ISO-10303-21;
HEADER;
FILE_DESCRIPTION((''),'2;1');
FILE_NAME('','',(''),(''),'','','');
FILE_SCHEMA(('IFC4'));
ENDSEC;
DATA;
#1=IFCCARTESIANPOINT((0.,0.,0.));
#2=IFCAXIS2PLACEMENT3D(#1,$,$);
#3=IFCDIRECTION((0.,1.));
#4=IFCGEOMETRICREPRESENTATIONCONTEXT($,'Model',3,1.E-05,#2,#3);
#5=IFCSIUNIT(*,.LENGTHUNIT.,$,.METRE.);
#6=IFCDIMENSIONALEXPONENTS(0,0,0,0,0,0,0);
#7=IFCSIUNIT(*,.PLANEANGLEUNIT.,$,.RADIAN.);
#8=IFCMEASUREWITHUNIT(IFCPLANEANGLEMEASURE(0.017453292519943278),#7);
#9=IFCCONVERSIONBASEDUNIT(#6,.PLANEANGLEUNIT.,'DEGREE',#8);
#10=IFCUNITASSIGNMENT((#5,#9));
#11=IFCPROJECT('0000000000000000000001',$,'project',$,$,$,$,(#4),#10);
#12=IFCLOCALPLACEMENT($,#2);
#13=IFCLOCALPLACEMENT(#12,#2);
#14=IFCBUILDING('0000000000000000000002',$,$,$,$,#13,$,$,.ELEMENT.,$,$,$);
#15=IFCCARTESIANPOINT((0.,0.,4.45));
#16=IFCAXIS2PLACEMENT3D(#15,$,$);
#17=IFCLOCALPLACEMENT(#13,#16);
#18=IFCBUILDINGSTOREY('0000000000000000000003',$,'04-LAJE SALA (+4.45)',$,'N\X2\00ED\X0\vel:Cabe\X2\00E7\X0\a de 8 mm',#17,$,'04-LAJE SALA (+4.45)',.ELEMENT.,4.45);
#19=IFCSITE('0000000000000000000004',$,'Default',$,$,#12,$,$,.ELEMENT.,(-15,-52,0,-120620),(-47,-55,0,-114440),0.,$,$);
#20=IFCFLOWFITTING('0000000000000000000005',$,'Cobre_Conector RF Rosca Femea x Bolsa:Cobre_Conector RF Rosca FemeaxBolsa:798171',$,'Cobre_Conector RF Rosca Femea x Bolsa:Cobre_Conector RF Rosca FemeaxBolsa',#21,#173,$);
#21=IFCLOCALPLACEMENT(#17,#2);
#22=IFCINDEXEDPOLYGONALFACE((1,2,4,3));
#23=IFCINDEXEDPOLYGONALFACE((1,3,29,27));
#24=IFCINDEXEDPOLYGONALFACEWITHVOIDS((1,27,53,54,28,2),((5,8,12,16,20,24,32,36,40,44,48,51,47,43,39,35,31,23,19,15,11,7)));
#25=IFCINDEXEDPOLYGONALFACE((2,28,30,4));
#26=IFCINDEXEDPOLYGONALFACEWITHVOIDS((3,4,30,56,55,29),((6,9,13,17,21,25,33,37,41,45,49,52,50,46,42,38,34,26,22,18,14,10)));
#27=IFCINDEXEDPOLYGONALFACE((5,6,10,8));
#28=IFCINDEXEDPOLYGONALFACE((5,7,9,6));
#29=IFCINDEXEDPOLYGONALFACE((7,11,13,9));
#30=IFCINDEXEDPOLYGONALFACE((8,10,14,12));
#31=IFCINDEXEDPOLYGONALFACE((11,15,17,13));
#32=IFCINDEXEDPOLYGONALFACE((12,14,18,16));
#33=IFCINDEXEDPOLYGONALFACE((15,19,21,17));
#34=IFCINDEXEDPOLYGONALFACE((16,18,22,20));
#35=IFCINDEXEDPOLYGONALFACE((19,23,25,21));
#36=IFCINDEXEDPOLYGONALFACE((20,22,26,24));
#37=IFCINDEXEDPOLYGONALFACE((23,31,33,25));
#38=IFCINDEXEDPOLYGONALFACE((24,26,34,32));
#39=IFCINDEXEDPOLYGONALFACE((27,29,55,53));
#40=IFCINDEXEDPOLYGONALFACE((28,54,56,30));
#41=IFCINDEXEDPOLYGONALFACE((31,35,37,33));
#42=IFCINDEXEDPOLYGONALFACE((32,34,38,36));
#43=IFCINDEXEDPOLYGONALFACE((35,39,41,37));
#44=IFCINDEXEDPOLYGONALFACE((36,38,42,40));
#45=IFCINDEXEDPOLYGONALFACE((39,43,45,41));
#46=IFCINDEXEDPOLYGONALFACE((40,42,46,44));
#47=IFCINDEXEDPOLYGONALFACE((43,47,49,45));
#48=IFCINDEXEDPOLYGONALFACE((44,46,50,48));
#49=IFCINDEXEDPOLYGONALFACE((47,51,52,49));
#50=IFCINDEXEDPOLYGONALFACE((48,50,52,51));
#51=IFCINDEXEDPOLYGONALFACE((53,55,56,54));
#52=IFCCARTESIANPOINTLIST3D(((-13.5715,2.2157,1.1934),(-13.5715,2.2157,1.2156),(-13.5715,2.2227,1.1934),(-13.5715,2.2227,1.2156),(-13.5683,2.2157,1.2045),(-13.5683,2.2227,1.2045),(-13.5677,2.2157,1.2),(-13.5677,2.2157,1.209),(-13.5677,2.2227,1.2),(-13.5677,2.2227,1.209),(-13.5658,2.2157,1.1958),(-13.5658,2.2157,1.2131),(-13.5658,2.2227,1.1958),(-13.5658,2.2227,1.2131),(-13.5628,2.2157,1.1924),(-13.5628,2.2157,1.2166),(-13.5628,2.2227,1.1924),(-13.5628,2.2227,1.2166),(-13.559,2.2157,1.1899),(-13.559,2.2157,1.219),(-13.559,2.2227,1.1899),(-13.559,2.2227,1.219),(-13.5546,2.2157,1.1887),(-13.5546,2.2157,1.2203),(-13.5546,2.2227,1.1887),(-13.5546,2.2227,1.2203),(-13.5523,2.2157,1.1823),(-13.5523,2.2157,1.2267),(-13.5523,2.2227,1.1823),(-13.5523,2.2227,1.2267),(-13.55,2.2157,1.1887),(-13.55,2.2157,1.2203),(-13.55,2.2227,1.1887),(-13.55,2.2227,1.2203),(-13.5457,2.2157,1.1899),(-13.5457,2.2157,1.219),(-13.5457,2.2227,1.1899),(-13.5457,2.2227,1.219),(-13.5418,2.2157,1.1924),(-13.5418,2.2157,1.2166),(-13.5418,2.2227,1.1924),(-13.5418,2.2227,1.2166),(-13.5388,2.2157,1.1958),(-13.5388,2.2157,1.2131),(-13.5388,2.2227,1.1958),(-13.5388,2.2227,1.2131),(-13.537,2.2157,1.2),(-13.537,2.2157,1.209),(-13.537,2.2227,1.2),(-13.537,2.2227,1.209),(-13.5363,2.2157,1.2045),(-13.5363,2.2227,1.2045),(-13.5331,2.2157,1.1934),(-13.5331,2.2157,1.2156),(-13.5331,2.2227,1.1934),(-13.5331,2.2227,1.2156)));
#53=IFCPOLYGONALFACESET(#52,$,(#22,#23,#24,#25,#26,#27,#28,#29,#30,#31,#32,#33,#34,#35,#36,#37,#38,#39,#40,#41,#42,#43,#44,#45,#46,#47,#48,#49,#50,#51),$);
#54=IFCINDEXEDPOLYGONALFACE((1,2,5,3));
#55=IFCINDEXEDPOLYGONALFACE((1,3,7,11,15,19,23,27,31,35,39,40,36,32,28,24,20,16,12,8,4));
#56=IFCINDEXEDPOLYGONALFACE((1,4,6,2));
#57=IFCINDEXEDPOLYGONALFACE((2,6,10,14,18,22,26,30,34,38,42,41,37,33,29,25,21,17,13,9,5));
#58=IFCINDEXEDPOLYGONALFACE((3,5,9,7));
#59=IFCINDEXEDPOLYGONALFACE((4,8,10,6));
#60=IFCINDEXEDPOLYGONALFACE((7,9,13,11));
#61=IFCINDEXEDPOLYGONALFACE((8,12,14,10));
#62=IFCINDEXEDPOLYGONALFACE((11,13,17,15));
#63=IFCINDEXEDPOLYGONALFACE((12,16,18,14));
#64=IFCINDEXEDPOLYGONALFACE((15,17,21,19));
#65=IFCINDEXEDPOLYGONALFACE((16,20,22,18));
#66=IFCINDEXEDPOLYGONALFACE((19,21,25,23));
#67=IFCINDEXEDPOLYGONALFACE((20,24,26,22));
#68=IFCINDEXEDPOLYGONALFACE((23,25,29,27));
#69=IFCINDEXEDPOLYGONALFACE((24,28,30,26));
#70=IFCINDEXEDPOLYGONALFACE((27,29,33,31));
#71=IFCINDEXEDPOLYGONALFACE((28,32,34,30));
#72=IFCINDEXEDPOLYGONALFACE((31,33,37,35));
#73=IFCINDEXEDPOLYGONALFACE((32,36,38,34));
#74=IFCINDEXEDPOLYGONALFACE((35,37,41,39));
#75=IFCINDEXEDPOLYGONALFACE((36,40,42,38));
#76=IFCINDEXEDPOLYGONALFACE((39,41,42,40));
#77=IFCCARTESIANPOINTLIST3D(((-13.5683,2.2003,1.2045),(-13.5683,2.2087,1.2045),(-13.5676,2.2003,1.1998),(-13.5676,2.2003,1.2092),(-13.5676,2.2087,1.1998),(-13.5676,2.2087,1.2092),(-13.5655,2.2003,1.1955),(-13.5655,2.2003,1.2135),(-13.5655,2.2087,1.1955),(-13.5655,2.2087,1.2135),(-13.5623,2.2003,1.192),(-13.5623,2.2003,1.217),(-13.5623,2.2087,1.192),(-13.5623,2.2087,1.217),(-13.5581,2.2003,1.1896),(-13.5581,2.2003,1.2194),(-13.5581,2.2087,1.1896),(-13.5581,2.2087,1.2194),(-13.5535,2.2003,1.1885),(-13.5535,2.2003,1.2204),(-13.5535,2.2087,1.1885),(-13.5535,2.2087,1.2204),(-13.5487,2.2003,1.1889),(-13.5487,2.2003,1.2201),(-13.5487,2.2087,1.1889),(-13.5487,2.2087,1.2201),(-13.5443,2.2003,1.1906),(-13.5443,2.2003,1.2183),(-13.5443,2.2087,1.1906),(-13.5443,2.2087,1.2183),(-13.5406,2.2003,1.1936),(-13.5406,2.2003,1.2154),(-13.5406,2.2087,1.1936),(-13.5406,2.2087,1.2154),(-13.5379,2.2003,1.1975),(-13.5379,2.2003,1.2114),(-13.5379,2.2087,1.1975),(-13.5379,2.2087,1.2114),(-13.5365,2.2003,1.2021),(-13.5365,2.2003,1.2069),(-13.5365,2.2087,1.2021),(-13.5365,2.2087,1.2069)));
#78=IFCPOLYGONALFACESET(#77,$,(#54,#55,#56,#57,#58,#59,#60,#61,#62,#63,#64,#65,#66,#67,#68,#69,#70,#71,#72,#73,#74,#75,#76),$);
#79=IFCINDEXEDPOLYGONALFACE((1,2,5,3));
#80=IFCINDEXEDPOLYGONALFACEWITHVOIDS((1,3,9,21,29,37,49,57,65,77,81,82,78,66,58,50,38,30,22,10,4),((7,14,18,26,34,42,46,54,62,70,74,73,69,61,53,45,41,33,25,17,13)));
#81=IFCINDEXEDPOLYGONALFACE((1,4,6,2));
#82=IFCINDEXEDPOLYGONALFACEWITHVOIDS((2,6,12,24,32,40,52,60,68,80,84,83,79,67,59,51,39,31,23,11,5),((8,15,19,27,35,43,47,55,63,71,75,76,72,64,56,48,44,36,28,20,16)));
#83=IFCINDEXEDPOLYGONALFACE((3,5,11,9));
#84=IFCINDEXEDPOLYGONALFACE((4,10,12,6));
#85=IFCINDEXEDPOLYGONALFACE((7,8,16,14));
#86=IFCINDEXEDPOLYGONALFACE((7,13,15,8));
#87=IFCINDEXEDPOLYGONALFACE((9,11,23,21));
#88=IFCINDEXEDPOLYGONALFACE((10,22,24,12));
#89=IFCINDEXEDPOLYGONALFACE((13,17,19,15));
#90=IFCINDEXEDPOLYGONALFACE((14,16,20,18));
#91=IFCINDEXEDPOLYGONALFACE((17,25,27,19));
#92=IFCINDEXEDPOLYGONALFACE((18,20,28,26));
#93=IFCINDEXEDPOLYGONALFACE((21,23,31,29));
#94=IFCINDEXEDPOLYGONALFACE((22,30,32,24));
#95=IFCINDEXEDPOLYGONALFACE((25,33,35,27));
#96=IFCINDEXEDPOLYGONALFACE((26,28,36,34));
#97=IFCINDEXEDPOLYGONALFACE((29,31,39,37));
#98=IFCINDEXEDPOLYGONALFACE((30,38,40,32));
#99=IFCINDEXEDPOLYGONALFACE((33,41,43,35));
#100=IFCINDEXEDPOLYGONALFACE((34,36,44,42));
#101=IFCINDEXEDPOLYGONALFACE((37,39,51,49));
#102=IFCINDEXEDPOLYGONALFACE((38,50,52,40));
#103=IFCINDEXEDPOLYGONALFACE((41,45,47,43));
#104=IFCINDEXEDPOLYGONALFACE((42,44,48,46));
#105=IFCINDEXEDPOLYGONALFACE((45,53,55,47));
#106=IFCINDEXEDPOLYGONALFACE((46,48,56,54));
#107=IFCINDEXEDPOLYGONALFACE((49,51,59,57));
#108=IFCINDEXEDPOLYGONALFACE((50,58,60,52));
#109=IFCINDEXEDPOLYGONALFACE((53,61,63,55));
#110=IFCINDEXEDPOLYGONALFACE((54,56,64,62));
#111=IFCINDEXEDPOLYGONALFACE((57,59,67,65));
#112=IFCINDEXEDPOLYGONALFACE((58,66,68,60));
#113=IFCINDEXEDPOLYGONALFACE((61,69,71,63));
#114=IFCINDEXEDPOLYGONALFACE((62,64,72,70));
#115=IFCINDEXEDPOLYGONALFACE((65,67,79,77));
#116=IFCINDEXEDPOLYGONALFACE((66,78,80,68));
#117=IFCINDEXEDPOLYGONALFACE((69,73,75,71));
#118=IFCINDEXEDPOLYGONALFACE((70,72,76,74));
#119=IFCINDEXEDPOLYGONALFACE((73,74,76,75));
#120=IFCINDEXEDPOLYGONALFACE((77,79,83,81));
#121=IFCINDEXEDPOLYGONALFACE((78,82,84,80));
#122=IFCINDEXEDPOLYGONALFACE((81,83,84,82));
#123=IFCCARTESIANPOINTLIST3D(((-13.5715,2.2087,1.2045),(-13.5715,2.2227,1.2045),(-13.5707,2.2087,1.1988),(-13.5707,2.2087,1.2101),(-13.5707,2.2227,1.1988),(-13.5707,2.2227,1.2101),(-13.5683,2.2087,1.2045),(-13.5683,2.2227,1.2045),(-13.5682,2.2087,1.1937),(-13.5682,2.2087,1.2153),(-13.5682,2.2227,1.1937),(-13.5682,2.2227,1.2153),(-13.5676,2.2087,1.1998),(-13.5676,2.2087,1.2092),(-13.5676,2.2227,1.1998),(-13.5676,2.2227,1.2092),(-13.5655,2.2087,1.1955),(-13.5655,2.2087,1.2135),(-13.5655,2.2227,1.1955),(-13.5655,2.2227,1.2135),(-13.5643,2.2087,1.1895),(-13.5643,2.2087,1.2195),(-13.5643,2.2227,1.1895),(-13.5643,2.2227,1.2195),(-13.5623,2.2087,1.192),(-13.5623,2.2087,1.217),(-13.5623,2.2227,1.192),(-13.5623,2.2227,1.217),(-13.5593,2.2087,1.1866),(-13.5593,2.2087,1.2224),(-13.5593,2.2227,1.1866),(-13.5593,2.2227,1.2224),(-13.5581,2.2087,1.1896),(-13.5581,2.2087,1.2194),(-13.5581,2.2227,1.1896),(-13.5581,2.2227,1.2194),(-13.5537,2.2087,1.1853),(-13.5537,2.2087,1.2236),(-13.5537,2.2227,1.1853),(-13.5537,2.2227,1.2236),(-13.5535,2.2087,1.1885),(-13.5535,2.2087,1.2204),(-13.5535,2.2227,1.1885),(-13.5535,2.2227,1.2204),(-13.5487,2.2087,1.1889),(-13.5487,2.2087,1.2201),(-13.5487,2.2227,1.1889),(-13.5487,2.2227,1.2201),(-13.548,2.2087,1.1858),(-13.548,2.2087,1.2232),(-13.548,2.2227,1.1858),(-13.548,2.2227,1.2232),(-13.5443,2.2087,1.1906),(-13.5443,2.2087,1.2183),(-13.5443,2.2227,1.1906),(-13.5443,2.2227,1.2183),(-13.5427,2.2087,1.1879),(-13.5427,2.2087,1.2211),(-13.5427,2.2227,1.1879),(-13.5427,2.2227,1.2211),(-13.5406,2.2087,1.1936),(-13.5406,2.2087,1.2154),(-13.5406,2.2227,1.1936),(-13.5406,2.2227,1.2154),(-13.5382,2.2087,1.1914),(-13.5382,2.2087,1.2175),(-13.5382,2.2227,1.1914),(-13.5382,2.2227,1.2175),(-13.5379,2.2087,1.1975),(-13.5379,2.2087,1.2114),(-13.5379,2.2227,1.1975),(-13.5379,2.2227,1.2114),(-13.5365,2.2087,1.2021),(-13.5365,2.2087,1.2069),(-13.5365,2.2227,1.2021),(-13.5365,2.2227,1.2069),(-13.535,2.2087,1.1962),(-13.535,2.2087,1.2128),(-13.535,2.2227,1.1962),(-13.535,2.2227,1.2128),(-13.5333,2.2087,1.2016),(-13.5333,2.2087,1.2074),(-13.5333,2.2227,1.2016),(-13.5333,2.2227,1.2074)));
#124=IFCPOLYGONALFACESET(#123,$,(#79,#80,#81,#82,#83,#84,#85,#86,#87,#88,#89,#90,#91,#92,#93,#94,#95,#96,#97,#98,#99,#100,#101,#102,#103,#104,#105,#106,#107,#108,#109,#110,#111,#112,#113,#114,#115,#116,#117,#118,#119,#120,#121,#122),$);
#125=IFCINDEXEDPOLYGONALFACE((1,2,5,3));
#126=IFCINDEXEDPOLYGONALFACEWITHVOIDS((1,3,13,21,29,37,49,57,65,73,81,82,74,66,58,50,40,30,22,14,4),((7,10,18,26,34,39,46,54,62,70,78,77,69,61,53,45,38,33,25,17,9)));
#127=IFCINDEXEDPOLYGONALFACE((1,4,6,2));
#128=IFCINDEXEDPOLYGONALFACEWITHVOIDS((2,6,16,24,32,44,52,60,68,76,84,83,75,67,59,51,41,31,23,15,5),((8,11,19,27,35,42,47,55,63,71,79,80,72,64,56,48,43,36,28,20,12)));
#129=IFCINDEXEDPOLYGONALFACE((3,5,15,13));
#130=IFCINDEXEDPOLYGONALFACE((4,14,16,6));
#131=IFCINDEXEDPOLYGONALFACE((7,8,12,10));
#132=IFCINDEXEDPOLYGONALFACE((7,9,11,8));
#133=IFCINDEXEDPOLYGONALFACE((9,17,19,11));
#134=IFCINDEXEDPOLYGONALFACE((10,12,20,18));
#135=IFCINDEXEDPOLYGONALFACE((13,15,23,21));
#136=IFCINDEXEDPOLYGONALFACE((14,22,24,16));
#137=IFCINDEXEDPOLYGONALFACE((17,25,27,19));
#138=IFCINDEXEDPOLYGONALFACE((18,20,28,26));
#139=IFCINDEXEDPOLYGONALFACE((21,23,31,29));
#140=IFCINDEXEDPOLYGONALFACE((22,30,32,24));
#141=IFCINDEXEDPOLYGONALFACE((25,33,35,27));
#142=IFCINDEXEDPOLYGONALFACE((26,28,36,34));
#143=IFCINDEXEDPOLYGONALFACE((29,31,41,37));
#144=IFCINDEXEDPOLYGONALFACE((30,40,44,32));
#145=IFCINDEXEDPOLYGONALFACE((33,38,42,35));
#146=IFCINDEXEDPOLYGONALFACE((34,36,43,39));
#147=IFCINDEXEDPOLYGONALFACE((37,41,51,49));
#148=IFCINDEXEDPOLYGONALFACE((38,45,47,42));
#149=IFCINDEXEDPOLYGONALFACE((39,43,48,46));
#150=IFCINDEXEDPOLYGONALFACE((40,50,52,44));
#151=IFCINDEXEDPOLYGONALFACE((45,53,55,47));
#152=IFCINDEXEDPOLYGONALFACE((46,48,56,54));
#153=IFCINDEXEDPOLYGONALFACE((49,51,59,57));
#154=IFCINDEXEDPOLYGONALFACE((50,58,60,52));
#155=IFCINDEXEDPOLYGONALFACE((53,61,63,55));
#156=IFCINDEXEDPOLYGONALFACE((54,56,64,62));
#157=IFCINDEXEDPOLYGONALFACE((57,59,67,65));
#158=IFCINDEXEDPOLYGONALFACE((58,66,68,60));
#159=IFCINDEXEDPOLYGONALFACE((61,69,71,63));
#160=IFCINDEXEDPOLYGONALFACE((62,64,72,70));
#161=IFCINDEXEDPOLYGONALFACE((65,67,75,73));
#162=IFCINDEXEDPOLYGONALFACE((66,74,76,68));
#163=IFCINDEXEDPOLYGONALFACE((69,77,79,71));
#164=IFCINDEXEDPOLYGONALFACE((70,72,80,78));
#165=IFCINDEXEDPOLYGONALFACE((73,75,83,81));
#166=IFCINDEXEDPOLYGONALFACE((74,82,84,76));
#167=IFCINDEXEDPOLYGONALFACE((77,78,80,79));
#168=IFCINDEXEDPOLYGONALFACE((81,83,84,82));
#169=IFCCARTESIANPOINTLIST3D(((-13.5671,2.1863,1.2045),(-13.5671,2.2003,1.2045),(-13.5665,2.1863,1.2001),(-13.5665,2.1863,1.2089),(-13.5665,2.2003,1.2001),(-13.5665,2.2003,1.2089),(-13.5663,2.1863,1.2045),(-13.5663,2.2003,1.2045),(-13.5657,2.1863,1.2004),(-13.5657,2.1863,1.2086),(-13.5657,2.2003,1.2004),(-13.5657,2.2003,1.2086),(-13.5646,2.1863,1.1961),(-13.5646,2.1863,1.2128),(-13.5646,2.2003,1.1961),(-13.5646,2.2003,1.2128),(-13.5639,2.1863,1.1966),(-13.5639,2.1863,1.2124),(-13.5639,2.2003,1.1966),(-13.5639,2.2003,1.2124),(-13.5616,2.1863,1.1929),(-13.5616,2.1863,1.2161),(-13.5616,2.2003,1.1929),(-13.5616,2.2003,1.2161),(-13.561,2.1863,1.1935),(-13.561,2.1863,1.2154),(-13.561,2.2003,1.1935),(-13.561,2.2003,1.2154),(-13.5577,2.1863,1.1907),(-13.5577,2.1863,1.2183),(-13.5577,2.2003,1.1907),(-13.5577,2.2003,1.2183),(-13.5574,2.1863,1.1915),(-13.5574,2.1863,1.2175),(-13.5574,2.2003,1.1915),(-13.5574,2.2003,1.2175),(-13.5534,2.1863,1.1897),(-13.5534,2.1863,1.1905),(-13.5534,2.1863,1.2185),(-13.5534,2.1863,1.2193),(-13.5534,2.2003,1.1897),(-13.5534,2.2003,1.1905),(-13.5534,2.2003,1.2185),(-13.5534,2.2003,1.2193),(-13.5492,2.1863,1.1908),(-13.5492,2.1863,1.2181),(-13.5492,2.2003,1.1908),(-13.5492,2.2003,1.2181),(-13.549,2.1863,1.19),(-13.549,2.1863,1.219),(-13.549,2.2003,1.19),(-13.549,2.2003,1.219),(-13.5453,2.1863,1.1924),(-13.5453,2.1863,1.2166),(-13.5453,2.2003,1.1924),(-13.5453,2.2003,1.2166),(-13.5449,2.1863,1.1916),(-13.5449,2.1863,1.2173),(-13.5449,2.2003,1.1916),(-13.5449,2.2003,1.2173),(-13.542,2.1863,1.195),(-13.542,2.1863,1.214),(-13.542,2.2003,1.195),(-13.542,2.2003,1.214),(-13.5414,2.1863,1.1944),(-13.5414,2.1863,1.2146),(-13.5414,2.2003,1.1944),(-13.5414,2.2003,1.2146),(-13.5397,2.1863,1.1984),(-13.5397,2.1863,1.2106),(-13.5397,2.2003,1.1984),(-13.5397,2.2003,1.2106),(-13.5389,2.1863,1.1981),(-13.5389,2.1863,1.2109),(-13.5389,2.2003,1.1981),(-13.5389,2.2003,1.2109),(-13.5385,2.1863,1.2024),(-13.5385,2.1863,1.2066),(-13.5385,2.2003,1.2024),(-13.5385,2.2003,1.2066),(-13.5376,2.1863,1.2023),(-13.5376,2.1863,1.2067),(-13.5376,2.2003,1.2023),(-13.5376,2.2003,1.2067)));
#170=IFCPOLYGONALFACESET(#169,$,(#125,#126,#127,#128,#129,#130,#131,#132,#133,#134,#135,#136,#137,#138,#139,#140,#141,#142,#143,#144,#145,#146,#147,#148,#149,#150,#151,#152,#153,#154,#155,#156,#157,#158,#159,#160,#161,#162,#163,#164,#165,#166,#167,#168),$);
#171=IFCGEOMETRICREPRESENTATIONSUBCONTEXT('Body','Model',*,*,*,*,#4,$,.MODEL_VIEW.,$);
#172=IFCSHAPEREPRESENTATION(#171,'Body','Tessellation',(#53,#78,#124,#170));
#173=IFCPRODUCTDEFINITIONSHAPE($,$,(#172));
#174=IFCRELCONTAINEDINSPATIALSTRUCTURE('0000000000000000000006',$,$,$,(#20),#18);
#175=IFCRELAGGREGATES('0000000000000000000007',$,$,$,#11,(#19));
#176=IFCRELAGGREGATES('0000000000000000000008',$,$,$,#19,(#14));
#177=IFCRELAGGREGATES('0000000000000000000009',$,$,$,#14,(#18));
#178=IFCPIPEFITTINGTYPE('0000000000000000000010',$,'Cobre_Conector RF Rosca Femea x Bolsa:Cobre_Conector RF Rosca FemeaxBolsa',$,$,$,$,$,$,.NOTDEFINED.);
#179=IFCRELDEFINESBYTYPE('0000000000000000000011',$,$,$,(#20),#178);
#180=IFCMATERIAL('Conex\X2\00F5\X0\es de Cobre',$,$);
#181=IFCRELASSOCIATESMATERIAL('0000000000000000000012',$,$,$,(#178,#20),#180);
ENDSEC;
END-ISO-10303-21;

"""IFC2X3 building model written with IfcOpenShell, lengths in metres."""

from ifc_helpers import new_model, entity, si_unit, converted_unit, direction, frame, frame_2d, origin, place, context, subcontext, project, spatial, polyline, circle_curve, parameter, trimmed, segment, composite_curve, circle, hollow_circle, outline, extrude, source, transform, mapped, material, type_object, type_shapes, element, save


model = new_model("IFC2X3")

# Units and contexts
model_context = context("Model", 3, precision=1e-05, world=origin(), true_north=direction((0.0, 1.0)))
body_context = subcontext(model_context, "Body", "Model", "MODEL_VIEW")
ifc_project = project(units=[si_unit("LENGTHUNIT", "METRE"), converted_unit("PLANEANGLEUNIT", "DEGREE", entity("IfcPlaneAngleMeasure", 0.017453292519943278), si_unit("PLANEANGLEUNIT", "RADIAN"), dimensions=[0, 0, 0, 0, 0, 0, 0])], contexts=[model_context])

# Site, building, storey
site_placement = place(None, origin())
site = spatial("IfcSite", under=ifc_project, at=site_placement, Name="Default", CompositionType="ELEMENT", RefLatitude=(-15, -52, 0, -120620), RefLongitude=(-47, -55, 0, -114440), RefElevation=0.0)
building_placement = place(site_placement, origin())
building = spatial("IfcBuilding", under=site, at=building_placement, CompositionType="ELEMENT")
storey_placement = place(building_placement, frame((0.0, 0.0, 4.45)))
storey = spatial("IfcBuildingStorey", under=building, at=storey_placement, Name="04-LAJE SALA (+4.45)", ObjectType="Nível:Cabeça de 8 mm", LongName="04-LAJE SALA (+4.45)", CompositionType="ELEMENT", Elevation=4.45)

# Flow fitting
ifc_material_1 = material(Name="Conexões de Cobre")
pipe_fitting_type_1 = type_object("IfcPipeFittingType", Name="Cobre_Conector RF Rosca Femea x Bolsa:Cobre_Conector RF Rosca FemeaxBolsa", PredefinedType="NOTDEFINED", material=ifc_material_1)
shared_shape_1 = source(origin(), body_context, "Body", "SweptSolid", [
    extrude(outline(polyline([(-0.0111, -0.0192), (0.0111, -0.0192), (0.0222, 0.0), (0.0111, 0.0192), (-0.0111, 0.0192), (-0.0222, 0.0), (-0.0111, -0.0192)]), holes=[composite_curve([segment(trimmed(circle_curve(frame_2d((0.0, 0.0), x_axis=(0.0, 1.0)), 0.016), [parameter(0.0)], [parameter(180.0)], True, "PARAMETER"), False, "CONTINUOUS"), segment(trimmed(circle_curve(frame_2d((0.0, 0.0), x_axis=(0.0, 1.0)), 0.016), [parameter(180.0)], [parameter(0.0)], True, "PARAMETER"), False, "CONTINUOUS")], self_intersect=False)]), frame((0.0294, 0.0, 0.0), z_axis=(1.0, 0.0, 0.0), x_axis=(0.0, 0.0, -1.0)), (0.0, 0.0, 1.0), 0.007),
    extrude(circle(Radius=0.016, at=frame_2d((0.0, 0.0), x_axis=(1.0, 0.0))), frame((0.014, 0.0, 0.0), z_axis=(1.0, 0.0, 0.0), x_axis=(0.0, 1.0, 0.0)), (0.0, 0.0, 1.0), 0.0084),
    extrude(hollow_circle(Radius=0.0192, WallThickness=0.0032, at=frame_2d((0.0, 0.0), x_axis=(1.0, 0.0))), frame((0.0224, 0.0, 0.0), z_axis=(1.0, 0.0, 0.0), x_axis=(0.0, 1.0, 0.0)), (0.0, 0.0, 1.0), 0.014),
    extrude(hollow_circle(Radius=0.0148, WallThickness=0.0008, at=frame_2d((0.0, 0.0), x_axis=(1.0, 0.0))), frame((0.0, 0.0, 0.0), z_axis=(1.0, 0.0, 0.0), x_axis=(0.0, 1.0, 0.0)), (0.0, 0.0, 1.0), 0.014),
])
type_shapes(pipe_fitting_type_1, [shared_shape_1])
for number, where, z_axis, x_axis, name in (
    (1, (-13.5523, 2.1863, 1.2045), (0.0, 0.0, 1.0), (0.0, 1.0, 0.0), "Cobre_Conector RF Rosca Femea x Bolsa:Cobre_Conector RF Rosca FemeaxBolsa:798171"),
):
    element("IfcFlowFitting", number, at=place(storey_placement, frame(where, z_axis=z_axis, x_axis=x_axis)), inside=storey, type_object=pipe_fitting_type_1, material=ifc_material_1, Name=name, ObjectType="Cobre_Conector RF Rosca Femea x Bolsa:Cobre_Conector RF Rosca FemeaxBolsa", context=body_context, shape_type="MappedRepresentation", body=[
        mapped(shared_shape_1, transform((0.0, 0.0, 0.0), scale=1.0)),
    ])

save(model, "model.ifc")
